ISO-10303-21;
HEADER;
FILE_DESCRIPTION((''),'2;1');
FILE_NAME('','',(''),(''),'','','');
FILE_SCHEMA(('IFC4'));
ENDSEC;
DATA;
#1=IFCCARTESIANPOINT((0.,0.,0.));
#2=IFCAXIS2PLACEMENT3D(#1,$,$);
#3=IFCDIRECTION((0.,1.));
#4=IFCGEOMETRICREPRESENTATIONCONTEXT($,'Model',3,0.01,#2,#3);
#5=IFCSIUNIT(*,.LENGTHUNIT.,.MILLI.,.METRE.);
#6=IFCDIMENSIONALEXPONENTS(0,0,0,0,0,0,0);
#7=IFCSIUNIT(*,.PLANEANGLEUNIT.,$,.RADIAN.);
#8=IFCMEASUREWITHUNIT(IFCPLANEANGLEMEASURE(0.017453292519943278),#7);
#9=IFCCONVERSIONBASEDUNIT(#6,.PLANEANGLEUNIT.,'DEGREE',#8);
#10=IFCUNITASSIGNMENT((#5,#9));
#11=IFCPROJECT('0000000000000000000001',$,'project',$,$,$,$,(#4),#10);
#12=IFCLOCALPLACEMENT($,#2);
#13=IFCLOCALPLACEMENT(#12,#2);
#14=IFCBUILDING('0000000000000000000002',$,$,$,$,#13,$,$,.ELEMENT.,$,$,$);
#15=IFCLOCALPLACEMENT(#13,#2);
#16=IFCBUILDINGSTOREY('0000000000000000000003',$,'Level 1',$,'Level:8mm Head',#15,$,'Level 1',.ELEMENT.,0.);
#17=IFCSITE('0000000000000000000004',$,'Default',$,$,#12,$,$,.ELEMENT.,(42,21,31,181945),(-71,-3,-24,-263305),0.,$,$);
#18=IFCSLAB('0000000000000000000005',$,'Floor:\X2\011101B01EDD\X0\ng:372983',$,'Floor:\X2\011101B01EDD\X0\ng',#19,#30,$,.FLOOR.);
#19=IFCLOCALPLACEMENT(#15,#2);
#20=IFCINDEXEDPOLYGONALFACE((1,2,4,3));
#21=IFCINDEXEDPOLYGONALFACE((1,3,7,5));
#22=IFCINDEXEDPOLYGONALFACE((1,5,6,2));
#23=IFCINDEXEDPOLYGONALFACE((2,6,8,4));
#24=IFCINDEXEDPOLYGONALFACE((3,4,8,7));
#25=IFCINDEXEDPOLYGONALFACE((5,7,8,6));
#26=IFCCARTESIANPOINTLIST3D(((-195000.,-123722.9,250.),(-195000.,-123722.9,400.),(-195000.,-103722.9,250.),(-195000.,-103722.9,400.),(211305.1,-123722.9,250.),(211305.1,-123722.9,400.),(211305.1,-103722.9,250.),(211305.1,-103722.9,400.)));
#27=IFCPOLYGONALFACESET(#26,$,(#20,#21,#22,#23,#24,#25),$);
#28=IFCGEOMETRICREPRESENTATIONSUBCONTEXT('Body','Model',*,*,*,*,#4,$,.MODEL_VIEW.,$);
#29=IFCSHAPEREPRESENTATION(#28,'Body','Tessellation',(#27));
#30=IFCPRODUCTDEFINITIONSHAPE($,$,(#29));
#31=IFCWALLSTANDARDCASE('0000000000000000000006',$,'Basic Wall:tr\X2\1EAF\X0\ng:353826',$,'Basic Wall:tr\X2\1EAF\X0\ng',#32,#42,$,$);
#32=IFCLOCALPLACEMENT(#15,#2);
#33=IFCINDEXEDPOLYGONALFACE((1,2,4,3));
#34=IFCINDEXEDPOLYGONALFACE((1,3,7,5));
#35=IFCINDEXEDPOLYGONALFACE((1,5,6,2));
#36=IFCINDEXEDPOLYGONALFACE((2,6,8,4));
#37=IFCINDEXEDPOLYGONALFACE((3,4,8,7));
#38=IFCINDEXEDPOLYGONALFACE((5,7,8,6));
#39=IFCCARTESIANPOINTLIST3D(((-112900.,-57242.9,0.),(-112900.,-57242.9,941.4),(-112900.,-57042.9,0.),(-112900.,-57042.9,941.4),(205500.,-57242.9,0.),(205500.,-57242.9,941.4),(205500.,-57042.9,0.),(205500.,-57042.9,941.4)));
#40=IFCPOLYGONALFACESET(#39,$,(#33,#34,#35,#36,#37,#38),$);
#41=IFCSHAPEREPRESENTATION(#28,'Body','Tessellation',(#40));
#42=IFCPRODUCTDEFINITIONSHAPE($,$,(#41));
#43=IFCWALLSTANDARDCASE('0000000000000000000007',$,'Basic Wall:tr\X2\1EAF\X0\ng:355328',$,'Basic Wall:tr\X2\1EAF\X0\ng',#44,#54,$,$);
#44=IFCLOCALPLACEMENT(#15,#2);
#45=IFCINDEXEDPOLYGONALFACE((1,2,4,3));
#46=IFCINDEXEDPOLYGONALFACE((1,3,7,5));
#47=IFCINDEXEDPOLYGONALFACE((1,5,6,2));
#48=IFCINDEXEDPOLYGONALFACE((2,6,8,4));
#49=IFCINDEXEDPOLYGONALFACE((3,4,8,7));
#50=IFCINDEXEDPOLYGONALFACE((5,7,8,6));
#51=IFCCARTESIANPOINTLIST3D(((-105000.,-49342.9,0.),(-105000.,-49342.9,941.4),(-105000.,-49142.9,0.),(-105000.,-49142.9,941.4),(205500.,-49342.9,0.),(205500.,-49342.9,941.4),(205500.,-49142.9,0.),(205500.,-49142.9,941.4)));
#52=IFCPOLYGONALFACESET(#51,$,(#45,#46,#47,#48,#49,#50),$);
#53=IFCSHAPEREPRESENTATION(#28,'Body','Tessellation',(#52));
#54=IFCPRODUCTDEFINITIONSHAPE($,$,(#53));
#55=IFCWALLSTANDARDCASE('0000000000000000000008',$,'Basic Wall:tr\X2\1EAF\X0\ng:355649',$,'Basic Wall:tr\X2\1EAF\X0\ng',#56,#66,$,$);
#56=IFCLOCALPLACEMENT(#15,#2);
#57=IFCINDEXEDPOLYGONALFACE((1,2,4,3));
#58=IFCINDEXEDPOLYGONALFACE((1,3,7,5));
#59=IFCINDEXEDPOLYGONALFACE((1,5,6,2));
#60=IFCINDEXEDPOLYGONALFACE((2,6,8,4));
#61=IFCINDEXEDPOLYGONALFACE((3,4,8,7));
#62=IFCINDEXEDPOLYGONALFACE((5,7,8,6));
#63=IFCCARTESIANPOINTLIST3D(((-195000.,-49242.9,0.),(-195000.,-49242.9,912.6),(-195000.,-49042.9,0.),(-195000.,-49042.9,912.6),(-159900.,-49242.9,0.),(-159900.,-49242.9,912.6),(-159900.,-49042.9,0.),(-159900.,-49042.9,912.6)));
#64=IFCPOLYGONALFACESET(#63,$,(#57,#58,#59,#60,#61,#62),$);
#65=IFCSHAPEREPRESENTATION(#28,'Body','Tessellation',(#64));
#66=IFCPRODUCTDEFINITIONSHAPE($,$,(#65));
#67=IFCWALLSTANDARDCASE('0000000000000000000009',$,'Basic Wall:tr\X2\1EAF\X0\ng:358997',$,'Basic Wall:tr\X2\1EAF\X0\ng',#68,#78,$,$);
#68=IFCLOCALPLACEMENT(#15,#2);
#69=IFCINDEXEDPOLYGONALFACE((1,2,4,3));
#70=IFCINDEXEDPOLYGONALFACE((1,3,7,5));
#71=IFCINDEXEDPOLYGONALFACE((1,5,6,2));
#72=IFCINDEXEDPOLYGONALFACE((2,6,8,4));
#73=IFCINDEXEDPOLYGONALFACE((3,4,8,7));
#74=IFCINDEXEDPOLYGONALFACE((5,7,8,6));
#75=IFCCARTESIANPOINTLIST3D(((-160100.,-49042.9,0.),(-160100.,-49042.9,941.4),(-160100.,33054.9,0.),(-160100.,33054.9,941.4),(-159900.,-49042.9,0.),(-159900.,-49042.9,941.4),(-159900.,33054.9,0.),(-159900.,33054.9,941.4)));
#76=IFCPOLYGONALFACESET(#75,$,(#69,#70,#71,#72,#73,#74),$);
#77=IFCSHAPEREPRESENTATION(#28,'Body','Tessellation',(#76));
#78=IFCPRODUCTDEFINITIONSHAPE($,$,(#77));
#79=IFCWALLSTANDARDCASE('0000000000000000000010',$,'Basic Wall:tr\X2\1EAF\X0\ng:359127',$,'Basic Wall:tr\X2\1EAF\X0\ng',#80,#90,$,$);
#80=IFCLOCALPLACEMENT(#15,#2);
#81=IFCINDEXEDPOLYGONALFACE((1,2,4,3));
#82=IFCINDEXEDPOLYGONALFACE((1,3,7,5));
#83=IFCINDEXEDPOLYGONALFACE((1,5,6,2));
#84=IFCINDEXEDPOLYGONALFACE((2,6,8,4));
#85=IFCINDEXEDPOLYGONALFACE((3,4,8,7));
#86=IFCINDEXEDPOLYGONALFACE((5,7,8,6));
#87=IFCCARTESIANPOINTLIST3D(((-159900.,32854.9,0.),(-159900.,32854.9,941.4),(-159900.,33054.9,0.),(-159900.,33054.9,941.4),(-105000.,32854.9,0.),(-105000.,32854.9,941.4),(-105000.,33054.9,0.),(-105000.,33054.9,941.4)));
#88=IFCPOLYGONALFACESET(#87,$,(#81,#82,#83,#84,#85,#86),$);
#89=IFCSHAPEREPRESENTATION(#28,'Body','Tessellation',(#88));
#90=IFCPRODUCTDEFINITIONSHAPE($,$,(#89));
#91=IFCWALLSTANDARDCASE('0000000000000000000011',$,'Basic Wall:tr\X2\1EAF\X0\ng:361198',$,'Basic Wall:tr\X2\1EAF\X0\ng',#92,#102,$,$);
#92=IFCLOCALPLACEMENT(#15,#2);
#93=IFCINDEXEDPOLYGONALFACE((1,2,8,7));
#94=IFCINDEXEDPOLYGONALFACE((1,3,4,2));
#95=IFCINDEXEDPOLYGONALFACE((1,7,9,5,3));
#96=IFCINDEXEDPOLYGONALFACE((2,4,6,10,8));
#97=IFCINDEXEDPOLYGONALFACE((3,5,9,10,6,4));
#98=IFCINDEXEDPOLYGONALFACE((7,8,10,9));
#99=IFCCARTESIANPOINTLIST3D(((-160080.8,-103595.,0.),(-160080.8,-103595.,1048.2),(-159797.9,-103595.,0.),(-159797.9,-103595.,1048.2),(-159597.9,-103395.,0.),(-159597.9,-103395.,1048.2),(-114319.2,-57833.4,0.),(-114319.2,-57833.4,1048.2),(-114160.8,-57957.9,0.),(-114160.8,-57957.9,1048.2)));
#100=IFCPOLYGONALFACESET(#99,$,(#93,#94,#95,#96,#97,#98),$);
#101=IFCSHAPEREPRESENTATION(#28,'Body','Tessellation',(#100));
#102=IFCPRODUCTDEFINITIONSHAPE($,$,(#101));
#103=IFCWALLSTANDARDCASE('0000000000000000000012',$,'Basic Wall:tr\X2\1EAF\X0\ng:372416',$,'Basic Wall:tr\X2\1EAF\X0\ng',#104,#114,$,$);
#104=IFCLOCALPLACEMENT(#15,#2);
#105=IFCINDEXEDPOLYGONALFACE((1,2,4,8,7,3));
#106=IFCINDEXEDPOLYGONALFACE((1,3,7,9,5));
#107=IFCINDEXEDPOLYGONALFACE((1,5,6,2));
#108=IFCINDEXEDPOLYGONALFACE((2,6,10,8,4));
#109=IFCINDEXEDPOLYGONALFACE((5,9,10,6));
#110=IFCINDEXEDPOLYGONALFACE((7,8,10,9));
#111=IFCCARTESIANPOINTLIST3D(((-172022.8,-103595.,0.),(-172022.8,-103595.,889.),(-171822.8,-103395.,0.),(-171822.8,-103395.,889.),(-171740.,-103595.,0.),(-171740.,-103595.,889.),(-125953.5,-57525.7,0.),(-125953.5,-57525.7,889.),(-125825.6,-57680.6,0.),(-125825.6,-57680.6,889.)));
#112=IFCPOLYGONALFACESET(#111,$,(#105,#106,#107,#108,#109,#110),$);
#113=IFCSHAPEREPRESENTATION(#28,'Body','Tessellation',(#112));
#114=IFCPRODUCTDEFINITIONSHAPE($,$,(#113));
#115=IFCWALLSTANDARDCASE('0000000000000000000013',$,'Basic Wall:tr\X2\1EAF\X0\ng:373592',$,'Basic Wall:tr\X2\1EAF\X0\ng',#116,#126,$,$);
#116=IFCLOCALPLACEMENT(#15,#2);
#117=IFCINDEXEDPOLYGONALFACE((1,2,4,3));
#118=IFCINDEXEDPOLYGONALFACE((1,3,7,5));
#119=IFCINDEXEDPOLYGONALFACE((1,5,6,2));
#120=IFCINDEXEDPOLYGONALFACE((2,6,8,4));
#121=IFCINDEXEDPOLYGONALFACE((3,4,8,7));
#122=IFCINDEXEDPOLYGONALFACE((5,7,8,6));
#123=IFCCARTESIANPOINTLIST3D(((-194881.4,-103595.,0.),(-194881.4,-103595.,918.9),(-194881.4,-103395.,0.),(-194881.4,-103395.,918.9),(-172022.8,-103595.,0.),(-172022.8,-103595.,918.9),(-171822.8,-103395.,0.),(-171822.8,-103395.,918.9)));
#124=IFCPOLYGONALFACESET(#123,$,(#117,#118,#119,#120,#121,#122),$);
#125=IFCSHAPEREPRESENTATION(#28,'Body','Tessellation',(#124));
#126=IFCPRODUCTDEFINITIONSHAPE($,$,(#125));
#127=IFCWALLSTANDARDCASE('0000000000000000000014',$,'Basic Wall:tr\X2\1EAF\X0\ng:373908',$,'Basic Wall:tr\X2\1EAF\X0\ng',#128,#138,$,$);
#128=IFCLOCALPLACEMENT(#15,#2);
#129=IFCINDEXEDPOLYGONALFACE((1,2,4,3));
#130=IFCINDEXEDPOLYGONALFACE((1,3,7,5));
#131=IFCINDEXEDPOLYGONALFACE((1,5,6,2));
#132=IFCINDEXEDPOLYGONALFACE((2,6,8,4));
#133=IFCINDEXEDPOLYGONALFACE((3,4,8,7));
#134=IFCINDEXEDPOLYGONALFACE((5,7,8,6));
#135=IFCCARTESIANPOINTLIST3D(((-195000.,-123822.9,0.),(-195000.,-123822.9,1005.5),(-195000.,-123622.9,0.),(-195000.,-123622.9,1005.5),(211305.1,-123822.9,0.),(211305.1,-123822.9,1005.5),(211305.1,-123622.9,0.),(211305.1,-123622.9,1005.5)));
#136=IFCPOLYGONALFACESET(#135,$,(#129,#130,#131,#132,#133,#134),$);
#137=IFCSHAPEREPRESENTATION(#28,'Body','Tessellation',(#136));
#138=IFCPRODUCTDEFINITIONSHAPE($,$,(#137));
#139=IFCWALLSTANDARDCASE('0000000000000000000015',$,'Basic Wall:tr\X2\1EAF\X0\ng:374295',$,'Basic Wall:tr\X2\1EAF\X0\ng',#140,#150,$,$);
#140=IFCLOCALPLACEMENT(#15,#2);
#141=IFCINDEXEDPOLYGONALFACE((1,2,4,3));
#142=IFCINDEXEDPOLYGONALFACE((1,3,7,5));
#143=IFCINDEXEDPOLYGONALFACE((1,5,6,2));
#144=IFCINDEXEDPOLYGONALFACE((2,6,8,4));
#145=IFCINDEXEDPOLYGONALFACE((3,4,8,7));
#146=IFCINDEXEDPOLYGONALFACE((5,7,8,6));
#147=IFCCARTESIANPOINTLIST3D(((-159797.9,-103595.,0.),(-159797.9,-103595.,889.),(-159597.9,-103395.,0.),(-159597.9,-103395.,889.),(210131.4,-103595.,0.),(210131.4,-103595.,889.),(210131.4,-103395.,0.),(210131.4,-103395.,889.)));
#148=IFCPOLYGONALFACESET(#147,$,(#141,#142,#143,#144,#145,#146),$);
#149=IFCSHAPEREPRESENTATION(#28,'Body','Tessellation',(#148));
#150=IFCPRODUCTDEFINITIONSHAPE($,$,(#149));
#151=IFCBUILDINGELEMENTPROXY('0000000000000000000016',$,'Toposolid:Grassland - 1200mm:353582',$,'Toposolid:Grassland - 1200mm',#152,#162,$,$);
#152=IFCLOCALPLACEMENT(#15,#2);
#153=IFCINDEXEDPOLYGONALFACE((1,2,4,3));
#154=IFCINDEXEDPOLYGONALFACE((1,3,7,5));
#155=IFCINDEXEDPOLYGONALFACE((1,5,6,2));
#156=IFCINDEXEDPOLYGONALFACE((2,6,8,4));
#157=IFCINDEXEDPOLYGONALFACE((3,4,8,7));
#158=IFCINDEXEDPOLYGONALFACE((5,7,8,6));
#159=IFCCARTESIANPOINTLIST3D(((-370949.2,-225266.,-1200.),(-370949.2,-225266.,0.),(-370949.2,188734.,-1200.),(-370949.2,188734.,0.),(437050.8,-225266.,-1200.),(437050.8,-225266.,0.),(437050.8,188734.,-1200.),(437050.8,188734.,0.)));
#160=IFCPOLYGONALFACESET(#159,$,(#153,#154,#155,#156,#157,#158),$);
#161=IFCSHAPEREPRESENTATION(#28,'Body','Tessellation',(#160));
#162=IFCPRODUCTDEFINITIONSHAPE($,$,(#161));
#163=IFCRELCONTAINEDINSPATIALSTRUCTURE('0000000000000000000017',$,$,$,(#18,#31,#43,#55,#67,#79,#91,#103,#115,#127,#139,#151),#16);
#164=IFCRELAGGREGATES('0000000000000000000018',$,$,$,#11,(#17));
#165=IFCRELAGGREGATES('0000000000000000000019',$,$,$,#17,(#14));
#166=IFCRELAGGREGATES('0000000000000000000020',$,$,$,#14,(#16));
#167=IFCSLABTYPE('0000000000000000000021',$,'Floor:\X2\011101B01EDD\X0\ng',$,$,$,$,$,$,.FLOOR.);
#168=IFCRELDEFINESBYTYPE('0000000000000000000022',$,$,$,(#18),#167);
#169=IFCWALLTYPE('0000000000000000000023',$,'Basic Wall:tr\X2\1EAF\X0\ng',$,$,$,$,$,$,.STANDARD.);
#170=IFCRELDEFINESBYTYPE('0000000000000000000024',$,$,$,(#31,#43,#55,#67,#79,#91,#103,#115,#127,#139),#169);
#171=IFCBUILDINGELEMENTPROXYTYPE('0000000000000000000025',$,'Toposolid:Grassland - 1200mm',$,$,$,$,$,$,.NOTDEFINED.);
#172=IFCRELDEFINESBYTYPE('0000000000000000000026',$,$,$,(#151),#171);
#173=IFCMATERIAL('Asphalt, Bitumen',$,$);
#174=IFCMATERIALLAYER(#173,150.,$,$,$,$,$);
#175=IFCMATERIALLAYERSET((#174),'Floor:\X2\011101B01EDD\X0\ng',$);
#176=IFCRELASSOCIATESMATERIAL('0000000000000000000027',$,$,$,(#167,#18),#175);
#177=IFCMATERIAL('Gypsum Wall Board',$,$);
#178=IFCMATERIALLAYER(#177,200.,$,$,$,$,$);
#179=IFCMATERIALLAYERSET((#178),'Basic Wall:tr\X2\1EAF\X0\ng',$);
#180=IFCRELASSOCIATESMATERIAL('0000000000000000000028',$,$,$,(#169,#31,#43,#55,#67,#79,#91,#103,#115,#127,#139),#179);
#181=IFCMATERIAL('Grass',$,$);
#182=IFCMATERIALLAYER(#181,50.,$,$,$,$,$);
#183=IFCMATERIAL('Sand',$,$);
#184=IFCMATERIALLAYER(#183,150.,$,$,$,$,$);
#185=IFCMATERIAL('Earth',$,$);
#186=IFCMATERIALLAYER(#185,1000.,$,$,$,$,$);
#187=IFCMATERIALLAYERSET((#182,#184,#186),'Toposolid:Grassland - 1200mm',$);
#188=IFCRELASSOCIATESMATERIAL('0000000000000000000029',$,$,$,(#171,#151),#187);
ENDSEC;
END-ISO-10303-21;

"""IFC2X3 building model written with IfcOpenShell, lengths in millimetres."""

from ifc_helpers import new_model, entity, si_unit, converted_unit, direction, frame, frame_2d, origin, origin_2d_with_axis, place, context, subcontext, project, spatial, polyline, rectangle, outline, extrude, material, layer, layer_set, layer_usage, type_object, element, save


model = new_model("IFC2X3")

# Units and contexts
model_context = context("Model", 3, precision=0.01, world=origin(), true_north=direction((0.0, 1.0)))
body_context = subcontext(model_context, "Body", "Model", "MODEL_VIEW")
ifc_project = project(units=[si_unit("LENGTHUNIT", "METRE", prefix="MILLI"), converted_unit("PLANEANGLEUNIT", "DEGREE", entity("IfcPlaneAngleMeasure", 0.017453292519943278), si_unit("PLANEANGLEUNIT", "RADIAN"), dimensions=[0, 0, 0, 0, 0, 0, 0])], contexts=[model_context])

# Site, building, storey
site_placement = place(None, origin())
site = spatial("IfcSite", under=ifc_project, at=site_placement, Name="Default", CompositionType="ELEMENT", RefLatitude=(42, 21, 31, 181945), RefLongitude=(-71, -3, -24, -263305), RefElevation=0.0)
building_placement = place(site_placement, origin())
building = spatial("IfcBuilding", under=site, at=building_placement, CompositionType="ELEMENT")
storey_placement = place(building_placement, origin())
storey = spatial("IfcBuildingStorey", under=building, at=storey_placement, Name="Level 1", ObjectType="Level:8mm Head", LongName="Level 1", CompositionType="ELEMENT", Elevation=0.0)

# Slab
ifc_material_1 = material(Name="Asphalt, Bitumen")
ifc_layer_1 = layer(ifc_material_1, 150.0)
ifc_layer_set_1 = layer_set([ifc_layer_1], Name="Floor:đường")
ifc_layer_usage_1 = layer_usage(ifc_layer_set_1, "AXIS3", "POSITIVE", 0.0)
slab_type = type_object("IfcSlabType", Name="Floor:đường", PredefinedType="FLOOR", material=ifc_layer_set_1)
slab_placement = place(storey_placement, origin())
element("IfcSlab", 1, at=slab_placement, inside=storey, type_object=slab_type, material=ifc_layer_usage_1, Name="Floor:đường:372983", ObjectType="Floor:đường", PredefinedType="FLOOR", context=body_context, shape_type="SweptSolid", body=[
    extrude(rectangle(XDim=20000.0, YDim=406305.1, at=frame_2d((0.0, 0.0), x_axis=(1.0, 0.0))), frame((8152.5, -113722.9, 400.0), z_axis=(0.0, 0.0, -1.0), x_axis=(0.0, 1.0, 0.0)), (0.0, 0.0, 1.0), 150.0),
])

# Walls
ifc_material_2 = material(Name="Gypsum Wall Board")
ifc_layer_2 = layer(ifc_material_2, 200.0)
ifc_layer_set_2 = layer_set([ifc_layer_2], Name="Basic Wall:trắng")
ifc_layer_usage_2 = layer_usage(ifc_layer_set_2, "AXIS2", "NEGATIVE", 100.0)
wall_type = type_object("IfcWallType", Name="Basic Wall:trắng", PredefinedType="STANDARD", material=ifc_layer_set_2)
wall_1_placement = place(storey_placement, frame((-112900.0, -57142.9, 0.0)))
element("IfcWallStandardCase", 2, at=wall_1_placement, inside=storey, type_object=wall_type, material=ifc_layer_usage_2, Name="Basic Wall:trắng:353826", ObjectType="Basic Wall:trắng", context=body_context, shape_type="SweptSolid", body=[
    extrude(rectangle(XDim=318400.0, YDim=200.0, at=frame_2d((159200.0, 0.0), x_axis=(-1.0, 0.0))), origin(), (0.0, 0.0, 1.0), 941.4),
])
ifc_layer_usage_3 = layer_usage(ifc_layer_set_2, "AXIS2", "NEGATIVE", 100.0)
wall_2_placement = place(storey_placement, frame((-105000.0, -49242.9, 0.0)))
element("IfcWallStandardCase", 3, at=wall_2_placement, inside=storey, type_object=wall_type, material=ifc_layer_usage_3, Name="Basic Wall:trắng:355328", ObjectType="Basic Wall:trắng", context=body_context, shape_type="SweptSolid", body=[
    extrude(rectangle(XDim=310500.0, YDim=200.0, at=frame_2d((155250.0, 0.0), x_axis=(-1.0, 0.0))), origin(), (0.0, 0.0, 1.0), 941.4),
])
ifc_layer_usage_4 = layer_usage(ifc_layer_set_2, "AXIS2", "NEGATIVE", 100.0)
wall_3_placement = place(storey_placement, frame((-159900.0, -49142.9, 0.0), z_axis=(0.0, 0.0, 1.0), x_axis=(-1.0, 0.0, 0.0)))
element("IfcWallStandardCase", 4, at=wall_3_placement, inside=storey, type_object=wall_type, material=ifc_layer_usage_4, Name="Basic Wall:trắng:355649", ObjectType="Basic Wall:trắng", context=body_context, shape_type="SweptSolid", body=[
    extrude(rectangle(XDim=35100.0, YDim=200.0, at=frame_2d((17550.0, 0.0), x_axis=(-1.0, 0.0))), origin(), (0.0, 0.0, 1.0), 912.6),
])
ifc_layer_usage_5 = layer_usage(ifc_layer_set_2, "AXIS2", "NEGATIVE", 100.0)
wall_4_placement = place(storey_placement, frame((-160000.0, -49042.9, 0.0), z_axis=(0.0, 0.0, 1.0), x_axis=(0.0, 1.0, 0.0)))
element("IfcWallStandardCase", 5, at=wall_4_placement, inside=storey, type_object=wall_type, material=ifc_layer_usage_5, Name="Basic Wall:trắng:358997", ObjectType="Basic Wall:trắng", context=body_context, shape_type="SweptSolid", body=[
    extrude(rectangle(XDim=82097.8, YDim=200.0, at=frame_2d((41048.9, 0.0), x_axis=(-1.0, 0.0))), origin(), (0.0, 0.0, 1.0), 941.4),
])
ifc_layer_usage_6 = layer_usage(ifc_layer_set_2, "AXIS2", "NEGATIVE", 100.0)
wall_5_placement = place(storey_placement, frame((-159900.0, 32954.9, 0.0)))
element("IfcWallStandardCase", 6, at=wall_5_placement, inside=storey, type_object=wall_type, material=ifc_layer_usage_6, Name="Basic Wall:trắng:359127", ObjectType="Basic Wall:trắng", context=body_context, shape_type="SweptSolid", body=[
    extrude(rectangle(XDim=54900.0, YDim=200.0, at=frame_2d((27450.0, 0.0), x_axis=(-1.0, 0.0))), origin(), (0.0, 0.0, 1.0), 941.4),
])
ifc_layer_usage_7 = layer_usage(ifc_layer_set_2, "AXIS2", "NEGATIVE", 100.0)
wall_6_placement = place(storey_placement, frame((-114231.5, -57887.2, 0.0), z_axis=(0.0, 0.0, 1.0), x_axis=(-0.707107, -0.707107, 0.0)))
element("IfcWallStandardCase", 7, at=wall_6_placement, inside=storey, type_object=wall_type, material=ifc_layer_usage_7, Name="Basic Wall:trắng:361198", ObjectType="Basic Wall:trắng", context=body_context, shape_type="SweptSolid", body=[
    extrude(outline(polyline([(64740.6, -100.0), (64540.6, 100.0), (64257.8, 100.0), (0.0, 100.0), (24.0, -100.0), (64740.6, -100.0)])), origin(), (0.0, 0.0, 1.0), 1048.2),
])
ifc_layer_usage_8 = layer_usage(ifc_layer_set_2, "AXIS2", "NEGATIVE", 100.0)
wall_7_placement = place(storey_placement, frame((-125882.8, -57596.4, 0.0), z_axis=(0.0, 0.0, 1.0), x_axis=(-0.707107, -0.707107, 0.0)))
element("IfcWallStandardCase", 8, at=wall_7_placement, inside=storey, type_object=wall_type, material=ifc_layer_usage_8, Name="Basic Wall:trắng:372416", ObjectType="Basic Wall:trắng", context=body_context, shape_type="SweptSolid", body=[
    extrude(outline(polyline([(65151.8, -100.0), (64951.8, 100.0), (19.1, 100.0), (0.0, -100.0), (64869.0, -100.0), (65151.8, -100.0)])), origin(), (0.0, 0.0, 1.0), 889.0),
])
ifc_layer_usage_9 = layer_usage(ifc_layer_set_2, "AXIS2", "NEGATIVE", 100.0)
wall_8_placement = place(storey_placement, frame((-171822.8, -103495.0, 0.0), z_axis=(0.0, 0.0, 1.0), x_axis=(-1.0, 0.0, 0.0)))
element("IfcWallStandardCase", 9, at=wall_8_placement, inside=storey, type_object=wall_type, material=ifc_layer_usage_9, Name="Basic Wall:trắng:373592", ObjectType="Basic Wall:trắng", context=body_context, shape_type="SweptSolid", body=[
    extrude(outline(polyline([(23058.6, -100.0), (23058.6, 100.0), (200.0, 100.0), (0.0, -100.0), (23058.6, -100.0)])), origin(), (0.0, 0.0, 1.0), 918.9),
])
ifc_layer_usage_10 = layer_usage(ifc_layer_set_2, "AXIS2", "NEGATIVE", 100.0)
wall_9_placement = place(storey_placement, frame((-195000.0, -123722.9, 0.0)))
element("IfcWallStandardCase", 10, at=wall_9_placement, inside=storey, type_object=wall_type, material=ifc_layer_usage_10, Name="Basic Wall:trắng:373908", ObjectType="Basic Wall:trắng", context=body_context, shape_type="SweptSolid", body=[
    extrude(rectangle(XDim=406305.1, YDim=200.0, at=frame_2d((203152.5, 0.0), x_axis=(-1.0, 0.0))), origin(), (0.0, 0.0, 1.0), 1005.5),
])
ifc_layer_usage_11 = layer_usage(ifc_layer_set_2, "AXIS2", "NEGATIVE", 100.0)
wall_10_placement = place(storey_placement, frame((-159797.9, -103495.0, 0.0)))
element("IfcWallStandardCase", 11, at=wall_10_placement, inside=storey, type_object=wall_type, material=ifc_layer_usage_11, Name="Basic Wall:trắng:374295", ObjectType="Basic Wall:trắng", context=body_context, shape_type="SweptSolid", body=[
    extrude(outline(polyline([(369929.3, -100.0), (369929.3, 100.0), (200.0, 100.0), (0.0, -100.0), (369929.3, -100.0)])), origin(), (0.0, 0.0, 1.0), 889.0),
])

# Building element proxy
ifc_material_3 = material(Name="Grass")
ifc_layer_3 = layer(ifc_material_3, 50.0)
ifc_material_4 = material(Name="Sand")
ifc_layer_4 = layer(ifc_material_4, 150.0)
ifc_material_5 = material(Name="Earth")
ifc_layer_5 = layer(ifc_material_5, 1000.0)
ifc_layer_set_3 = layer_set([ifc_layer_3, ifc_layer_4, ifc_layer_5], Name="Toposolid:Grassland - 1200mm")
ifc_layer_usage_12 = layer_usage(ifc_layer_set_3, "AXIS3", "NEGATIVE", 0.0)
building_element_proxy_type = type_object("IfcBuildingElementProxyType", Name="Toposolid:Grassland - 1200mm", PredefinedType="NOTDEFINED", material=ifc_layer_set_3)
proxy_placement = place(storey_placement, origin())
element("IfcBuildingElementProxy", 12, at=proxy_placement, inside=storey, type_object=building_element_proxy_type, material=ifc_layer_usage_12, Name="Toposolid:Grassland - 1200mm:353582", ObjectType="Toposolid:Grassland - 1200mm", context=body_context, shape_type="SweptSolid", body=[
    extrude(rectangle(XDim=808000.0, YDim=414000.0, at=origin_2d_with_axis()), frame((33050.8, -18266.0, -1200.0), z_axis=(0.0, 0.0, 1.0), x_axis=(-1.0, 0.0, 0.0)), (0.0, 0.0, 1.0), 1200.0),
])

save(model, "model.ifc")
